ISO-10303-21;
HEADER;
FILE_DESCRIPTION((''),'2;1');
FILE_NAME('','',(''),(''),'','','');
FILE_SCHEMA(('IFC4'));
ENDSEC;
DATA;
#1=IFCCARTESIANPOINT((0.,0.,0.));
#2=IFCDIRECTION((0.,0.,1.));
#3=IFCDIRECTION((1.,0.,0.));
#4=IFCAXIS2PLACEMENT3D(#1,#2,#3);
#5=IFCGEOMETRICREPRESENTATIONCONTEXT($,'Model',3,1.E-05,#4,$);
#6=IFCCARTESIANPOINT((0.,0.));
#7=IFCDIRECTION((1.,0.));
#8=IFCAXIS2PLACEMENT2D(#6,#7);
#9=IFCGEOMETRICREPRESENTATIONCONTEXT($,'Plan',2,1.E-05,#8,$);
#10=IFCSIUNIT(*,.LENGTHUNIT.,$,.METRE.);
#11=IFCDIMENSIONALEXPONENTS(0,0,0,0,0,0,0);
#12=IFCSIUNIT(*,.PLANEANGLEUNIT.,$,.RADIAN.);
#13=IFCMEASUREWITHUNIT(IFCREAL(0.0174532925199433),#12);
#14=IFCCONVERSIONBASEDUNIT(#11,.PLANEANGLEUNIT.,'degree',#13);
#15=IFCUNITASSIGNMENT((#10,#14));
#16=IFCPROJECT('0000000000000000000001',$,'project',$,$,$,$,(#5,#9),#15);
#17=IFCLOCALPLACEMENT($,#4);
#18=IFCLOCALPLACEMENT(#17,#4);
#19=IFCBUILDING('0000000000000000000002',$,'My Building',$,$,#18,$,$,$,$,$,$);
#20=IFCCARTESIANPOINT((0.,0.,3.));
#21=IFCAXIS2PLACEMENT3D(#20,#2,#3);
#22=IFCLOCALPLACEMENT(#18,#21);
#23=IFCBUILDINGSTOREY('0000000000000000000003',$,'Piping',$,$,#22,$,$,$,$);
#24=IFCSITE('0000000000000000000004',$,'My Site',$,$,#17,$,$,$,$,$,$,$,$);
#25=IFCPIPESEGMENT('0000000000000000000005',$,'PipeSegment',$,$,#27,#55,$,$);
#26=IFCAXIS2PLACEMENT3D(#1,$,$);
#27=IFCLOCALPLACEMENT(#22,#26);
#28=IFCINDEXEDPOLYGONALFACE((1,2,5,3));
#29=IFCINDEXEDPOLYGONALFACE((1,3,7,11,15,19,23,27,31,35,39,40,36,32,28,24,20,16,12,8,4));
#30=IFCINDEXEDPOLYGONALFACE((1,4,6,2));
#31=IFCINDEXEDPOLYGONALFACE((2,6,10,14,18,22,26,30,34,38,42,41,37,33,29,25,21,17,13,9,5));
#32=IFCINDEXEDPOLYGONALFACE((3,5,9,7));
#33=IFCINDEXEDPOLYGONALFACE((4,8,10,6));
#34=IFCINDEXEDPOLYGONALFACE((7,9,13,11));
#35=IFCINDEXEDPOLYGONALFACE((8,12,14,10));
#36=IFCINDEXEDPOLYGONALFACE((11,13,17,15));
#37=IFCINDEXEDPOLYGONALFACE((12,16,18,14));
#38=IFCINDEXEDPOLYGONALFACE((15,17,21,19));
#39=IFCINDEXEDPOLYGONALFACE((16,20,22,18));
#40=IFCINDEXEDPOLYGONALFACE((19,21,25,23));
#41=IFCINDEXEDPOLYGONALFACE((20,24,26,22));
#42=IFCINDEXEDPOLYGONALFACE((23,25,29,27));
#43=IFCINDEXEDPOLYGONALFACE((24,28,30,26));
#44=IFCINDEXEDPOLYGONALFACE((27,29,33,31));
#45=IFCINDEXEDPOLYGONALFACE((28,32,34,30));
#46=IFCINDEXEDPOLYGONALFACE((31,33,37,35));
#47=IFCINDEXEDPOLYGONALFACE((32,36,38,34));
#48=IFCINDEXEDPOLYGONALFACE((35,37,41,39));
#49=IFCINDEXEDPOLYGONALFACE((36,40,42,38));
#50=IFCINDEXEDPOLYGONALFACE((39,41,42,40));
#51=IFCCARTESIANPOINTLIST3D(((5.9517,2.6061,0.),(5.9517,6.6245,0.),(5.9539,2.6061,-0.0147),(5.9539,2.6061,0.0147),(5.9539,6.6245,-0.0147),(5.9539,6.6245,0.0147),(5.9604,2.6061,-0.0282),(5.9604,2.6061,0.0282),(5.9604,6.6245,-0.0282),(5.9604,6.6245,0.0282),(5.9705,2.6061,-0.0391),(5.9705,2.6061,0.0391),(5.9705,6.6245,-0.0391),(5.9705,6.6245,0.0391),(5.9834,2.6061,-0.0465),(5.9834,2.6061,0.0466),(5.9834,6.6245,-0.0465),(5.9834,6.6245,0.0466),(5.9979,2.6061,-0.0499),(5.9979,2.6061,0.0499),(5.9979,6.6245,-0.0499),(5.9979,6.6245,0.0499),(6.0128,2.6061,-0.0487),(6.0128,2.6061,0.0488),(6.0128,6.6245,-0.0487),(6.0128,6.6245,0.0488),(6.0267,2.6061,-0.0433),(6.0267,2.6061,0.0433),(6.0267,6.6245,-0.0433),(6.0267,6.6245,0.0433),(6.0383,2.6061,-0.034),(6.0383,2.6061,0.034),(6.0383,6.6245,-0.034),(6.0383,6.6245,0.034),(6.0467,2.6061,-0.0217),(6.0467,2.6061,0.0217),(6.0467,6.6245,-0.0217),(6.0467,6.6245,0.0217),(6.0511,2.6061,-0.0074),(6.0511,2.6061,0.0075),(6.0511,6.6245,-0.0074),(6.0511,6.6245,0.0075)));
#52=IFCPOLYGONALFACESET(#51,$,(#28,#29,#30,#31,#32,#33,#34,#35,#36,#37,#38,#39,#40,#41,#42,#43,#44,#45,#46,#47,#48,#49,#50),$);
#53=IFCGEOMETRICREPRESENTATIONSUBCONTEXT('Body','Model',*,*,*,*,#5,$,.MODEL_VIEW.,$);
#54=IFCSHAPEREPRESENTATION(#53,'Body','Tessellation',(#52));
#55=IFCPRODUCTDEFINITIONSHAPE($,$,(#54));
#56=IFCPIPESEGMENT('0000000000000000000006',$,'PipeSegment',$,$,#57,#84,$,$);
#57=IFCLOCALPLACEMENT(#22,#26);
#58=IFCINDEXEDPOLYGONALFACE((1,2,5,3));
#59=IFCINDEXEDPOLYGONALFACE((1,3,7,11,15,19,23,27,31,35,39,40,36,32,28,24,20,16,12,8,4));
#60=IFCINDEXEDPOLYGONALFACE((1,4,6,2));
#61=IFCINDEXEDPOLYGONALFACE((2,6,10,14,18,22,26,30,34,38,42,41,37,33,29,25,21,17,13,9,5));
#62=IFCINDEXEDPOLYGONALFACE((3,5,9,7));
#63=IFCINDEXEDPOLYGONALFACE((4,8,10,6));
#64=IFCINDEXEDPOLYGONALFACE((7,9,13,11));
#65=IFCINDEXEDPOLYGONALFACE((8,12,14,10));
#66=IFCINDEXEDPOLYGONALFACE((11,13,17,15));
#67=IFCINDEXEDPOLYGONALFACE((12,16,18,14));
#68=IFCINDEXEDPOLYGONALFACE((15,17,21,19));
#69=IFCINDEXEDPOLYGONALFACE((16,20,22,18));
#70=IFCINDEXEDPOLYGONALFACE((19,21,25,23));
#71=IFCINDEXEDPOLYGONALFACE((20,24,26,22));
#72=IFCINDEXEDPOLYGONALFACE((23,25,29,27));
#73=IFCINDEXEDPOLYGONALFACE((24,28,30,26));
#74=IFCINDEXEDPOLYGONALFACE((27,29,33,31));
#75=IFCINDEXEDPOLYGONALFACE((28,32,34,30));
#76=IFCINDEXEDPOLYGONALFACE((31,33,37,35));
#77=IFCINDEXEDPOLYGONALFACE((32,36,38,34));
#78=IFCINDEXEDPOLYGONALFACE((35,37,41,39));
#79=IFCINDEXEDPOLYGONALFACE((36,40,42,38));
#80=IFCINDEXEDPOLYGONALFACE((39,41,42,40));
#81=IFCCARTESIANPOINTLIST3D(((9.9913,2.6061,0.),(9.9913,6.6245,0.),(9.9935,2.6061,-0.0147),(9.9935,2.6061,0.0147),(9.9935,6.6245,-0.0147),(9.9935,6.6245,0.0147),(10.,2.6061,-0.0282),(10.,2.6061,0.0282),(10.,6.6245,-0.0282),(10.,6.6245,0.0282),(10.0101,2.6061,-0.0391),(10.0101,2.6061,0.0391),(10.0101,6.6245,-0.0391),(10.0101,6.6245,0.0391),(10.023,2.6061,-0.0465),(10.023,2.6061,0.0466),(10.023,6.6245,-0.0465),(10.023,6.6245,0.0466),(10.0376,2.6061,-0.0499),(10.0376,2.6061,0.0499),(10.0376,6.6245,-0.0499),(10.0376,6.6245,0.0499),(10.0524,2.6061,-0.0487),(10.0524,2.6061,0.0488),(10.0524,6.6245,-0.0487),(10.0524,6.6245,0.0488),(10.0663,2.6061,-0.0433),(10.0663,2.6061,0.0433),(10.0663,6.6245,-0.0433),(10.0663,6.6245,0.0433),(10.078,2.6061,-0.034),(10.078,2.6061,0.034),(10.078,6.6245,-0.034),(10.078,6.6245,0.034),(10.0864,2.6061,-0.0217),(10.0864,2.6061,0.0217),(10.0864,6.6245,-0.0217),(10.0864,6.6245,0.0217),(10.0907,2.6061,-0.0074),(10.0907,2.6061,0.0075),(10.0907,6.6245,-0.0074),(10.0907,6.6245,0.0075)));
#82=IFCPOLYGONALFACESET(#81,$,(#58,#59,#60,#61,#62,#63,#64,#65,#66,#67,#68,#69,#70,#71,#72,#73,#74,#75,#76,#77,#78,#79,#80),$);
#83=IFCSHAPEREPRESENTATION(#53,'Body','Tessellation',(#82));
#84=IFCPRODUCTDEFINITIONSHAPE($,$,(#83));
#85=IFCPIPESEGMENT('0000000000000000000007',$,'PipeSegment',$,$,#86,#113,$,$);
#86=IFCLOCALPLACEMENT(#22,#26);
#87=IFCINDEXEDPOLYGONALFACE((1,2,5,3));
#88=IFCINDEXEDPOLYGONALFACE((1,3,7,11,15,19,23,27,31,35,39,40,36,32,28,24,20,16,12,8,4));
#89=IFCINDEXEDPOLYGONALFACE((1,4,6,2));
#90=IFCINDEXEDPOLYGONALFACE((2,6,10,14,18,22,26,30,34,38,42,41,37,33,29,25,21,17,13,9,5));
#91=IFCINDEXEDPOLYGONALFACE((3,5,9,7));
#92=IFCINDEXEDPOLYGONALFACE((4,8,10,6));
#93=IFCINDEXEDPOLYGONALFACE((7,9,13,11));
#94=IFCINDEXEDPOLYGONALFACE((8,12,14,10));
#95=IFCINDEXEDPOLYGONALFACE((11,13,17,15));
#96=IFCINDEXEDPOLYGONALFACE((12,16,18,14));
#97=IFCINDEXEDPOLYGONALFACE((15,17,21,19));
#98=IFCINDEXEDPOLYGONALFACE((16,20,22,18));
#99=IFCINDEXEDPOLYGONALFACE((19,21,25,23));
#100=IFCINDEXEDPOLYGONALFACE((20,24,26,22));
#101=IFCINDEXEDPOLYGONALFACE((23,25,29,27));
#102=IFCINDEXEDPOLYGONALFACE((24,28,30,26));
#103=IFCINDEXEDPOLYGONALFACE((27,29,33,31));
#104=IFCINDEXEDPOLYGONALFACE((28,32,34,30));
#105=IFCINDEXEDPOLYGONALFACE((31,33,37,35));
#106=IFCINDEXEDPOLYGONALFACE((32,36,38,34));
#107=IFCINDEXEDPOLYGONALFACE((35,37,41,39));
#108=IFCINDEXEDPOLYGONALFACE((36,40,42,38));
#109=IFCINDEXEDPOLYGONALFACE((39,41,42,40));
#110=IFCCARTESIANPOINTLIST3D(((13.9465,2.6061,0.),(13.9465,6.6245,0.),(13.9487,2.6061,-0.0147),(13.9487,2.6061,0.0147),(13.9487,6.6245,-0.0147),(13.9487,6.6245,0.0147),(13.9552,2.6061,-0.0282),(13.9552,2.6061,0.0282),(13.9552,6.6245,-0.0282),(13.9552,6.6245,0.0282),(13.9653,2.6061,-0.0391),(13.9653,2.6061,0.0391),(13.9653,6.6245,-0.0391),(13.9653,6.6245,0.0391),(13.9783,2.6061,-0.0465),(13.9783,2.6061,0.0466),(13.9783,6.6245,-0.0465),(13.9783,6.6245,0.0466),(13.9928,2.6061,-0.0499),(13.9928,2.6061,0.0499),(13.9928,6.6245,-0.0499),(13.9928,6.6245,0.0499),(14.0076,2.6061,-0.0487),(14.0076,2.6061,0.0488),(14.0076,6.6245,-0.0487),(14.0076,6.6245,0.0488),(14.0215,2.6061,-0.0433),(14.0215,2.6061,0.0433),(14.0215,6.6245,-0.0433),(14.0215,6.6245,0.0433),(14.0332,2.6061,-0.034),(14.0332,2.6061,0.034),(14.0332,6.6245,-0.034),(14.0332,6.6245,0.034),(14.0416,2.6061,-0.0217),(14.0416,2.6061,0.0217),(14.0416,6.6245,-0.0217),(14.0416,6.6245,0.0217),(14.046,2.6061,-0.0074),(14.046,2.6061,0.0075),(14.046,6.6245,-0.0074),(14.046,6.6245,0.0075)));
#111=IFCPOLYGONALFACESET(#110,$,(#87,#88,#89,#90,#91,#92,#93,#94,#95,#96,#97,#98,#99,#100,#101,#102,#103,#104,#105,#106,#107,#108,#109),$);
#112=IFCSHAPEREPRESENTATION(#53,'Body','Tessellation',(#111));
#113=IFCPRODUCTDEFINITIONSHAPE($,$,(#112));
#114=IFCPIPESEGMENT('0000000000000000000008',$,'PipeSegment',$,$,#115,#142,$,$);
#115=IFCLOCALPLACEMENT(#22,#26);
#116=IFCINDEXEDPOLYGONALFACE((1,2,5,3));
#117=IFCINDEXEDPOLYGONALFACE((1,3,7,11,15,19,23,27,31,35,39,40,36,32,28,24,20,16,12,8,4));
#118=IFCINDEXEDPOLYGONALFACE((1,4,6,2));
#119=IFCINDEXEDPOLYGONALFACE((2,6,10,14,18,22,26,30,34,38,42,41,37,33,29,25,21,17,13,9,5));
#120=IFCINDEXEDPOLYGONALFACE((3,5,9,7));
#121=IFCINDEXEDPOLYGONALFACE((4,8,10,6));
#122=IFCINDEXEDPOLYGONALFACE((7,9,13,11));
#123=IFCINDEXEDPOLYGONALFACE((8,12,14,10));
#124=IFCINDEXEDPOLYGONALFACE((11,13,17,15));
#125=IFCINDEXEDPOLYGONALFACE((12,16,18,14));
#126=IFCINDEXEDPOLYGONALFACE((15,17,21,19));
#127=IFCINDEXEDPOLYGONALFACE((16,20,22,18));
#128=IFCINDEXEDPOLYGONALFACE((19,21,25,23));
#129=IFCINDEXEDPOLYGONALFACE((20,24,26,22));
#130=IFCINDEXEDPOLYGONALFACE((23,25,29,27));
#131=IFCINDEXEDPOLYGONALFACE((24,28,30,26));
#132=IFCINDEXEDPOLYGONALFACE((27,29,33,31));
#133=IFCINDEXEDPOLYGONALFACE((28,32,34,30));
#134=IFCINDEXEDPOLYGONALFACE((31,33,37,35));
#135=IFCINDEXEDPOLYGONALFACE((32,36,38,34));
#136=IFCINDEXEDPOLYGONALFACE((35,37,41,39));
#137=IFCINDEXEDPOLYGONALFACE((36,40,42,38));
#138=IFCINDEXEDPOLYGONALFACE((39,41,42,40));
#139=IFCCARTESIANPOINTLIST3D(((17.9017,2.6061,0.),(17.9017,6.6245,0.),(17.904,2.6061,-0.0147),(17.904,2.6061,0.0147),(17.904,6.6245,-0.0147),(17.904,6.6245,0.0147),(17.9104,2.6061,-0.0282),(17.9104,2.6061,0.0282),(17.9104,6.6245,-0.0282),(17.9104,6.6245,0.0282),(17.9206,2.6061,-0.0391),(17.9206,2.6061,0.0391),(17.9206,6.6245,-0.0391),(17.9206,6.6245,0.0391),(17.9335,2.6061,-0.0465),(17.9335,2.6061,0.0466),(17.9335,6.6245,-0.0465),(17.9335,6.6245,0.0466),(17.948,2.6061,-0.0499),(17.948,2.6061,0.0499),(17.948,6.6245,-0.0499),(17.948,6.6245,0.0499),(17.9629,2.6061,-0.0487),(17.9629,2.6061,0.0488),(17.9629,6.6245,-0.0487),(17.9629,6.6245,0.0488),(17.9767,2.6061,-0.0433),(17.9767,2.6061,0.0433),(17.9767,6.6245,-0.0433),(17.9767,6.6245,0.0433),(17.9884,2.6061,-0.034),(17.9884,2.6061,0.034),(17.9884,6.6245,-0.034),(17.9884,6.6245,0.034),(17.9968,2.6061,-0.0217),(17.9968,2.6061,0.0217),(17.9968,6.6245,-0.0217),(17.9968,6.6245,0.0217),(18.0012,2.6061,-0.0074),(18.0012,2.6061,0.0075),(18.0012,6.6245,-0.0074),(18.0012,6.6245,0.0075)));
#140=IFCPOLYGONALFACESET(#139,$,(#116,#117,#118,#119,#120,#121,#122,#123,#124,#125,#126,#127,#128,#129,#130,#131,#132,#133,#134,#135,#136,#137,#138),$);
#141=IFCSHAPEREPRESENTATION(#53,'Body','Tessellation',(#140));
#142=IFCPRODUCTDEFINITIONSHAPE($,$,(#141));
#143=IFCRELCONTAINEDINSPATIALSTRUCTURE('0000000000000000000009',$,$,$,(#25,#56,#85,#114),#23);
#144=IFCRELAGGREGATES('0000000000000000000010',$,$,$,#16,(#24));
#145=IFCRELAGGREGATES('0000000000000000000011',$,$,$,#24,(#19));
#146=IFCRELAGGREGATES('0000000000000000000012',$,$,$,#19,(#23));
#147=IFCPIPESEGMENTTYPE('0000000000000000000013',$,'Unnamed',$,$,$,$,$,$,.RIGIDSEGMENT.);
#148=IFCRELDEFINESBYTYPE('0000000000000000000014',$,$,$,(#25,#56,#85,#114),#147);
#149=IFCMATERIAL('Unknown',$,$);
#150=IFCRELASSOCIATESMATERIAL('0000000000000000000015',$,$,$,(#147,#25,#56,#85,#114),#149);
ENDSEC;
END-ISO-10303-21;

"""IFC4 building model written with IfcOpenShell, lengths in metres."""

from ifc_helpers import new_model, entity, si_unit, converted_unit, frame, origin_with_axes, origin_2d_with_axis, place, context, subcontext, project, spatial, circle, extrude, material, material_profile, profile_set, profile_usage, type_object, element, save


model = new_model("IFC4")

# Units and contexts
model_context = context("Model", 3, precision=1e-05, world=origin_with_axes())
plan_context = context("Plan", 2, precision=1e-05, world=origin_2d_with_axis())
body_context = subcontext(model_context, "Body", "Model", "MODEL_VIEW")
ifc_project = project(units=[si_unit("LENGTHUNIT", "METRE"), converted_unit("PLANEANGLEUNIT", "degree", entity("IfcReal", 0.0174532925199433), si_unit("PLANEANGLEUNIT", "RADIAN"), dimensions=[0, 0, 0, 0, 0, 0, 0])], contexts=[model_context, plan_context])

# Site, building, storey
site_placement = place(None, origin_with_axes())
site = spatial("IfcSite", under=ifc_project, at=site_placement, Name="My Site")
building_placement = place(site_placement, origin_with_axes())
building = spatial("IfcBuilding", under=site, at=building_placement, Name="My Building")
storey_placement = place(building_placement, frame((0.0, 0.0, 3.0), z_axis=(0.0, 0.0, 1.0), x_axis=(1.0, 0.0, 0.0)))
storey = spatial("IfcBuildingStorey", under=building, at=storey_placement, Name="Piping")

# Pipe segments
ifc_material = material(Name="Unknown")
ifc_material_profile = material_profile(ifc_material, circle(Radius=0.05))
ifc_profile_set = profile_set([ifc_material_profile])
pipe_segment_type = type_object("IfcPipeSegmentType", Name="Unnamed", PredefinedType="RIGIDSEGMENT", material=ifc_profile_set)
ifc_profile_usage_1 = profile_usage(ifc_profile_set, cardinal=5)
pipe_segment_1_placement = place(storey_placement, frame((6.0017, 2.6061, 0.0), z_axis=(0.0, 1.0, 0.0), x_axis=(-1.0, 0.0, 0.0)))
element("IfcPipeSegment", 1, at=pipe_segment_1_placement, inside=storey, type_object=pipe_segment_type, material=ifc_profile_usage_1, Name="PipeSegment", context=body_context, shape_type="SweptSolid", body=[
    extrude(circle(Radius=0.05), origin_with_axes(), (0.0, 0.0, 1.0), 4.0184),
])
ifc_profile_usage_2 = profile_usage(ifc_profile_set, cardinal=5)
pipe_segment_2_placement = place(storey_placement, frame((10.0413, 2.6061, 0.0), z_axis=(0.0, 1.0, 0.0), x_axis=(-1.0, 0.0, 0.0)))
element("IfcPipeSegment", 2, at=pipe_segment_2_placement, inside=storey, type_object=pipe_segment_type, material=ifc_profile_usage_2, Name="PipeSegment", context=body_context, shape_type="SweptSolid", body=[
    extrude(circle(Radius=0.05), origin_with_axes(), (0.0, 0.0, 1.0), 4.0184),
])
ifc_profile_usage_3 = profile_usage(ifc_profile_set, cardinal=5)
pipe_segment_3_placement = place(storey_placement, frame((13.9965, 2.6061, 0.0), z_axis=(0.0, 1.0, 0.0), x_axis=(-1.0, 0.0, 0.0)))
element("IfcPipeSegment", 3, at=pipe_segment_3_placement, inside=storey, type_object=pipe_segment_type, material=ifc_profile_usage_3, Name="PipeSegment", context=body_context, shape_type="SweptSolid", body=[
    extrude(circle(Radius=0.05), origin_with_axes(), (0.0, 0.0, 1.0), 4.0184),
])
ifc_profile_usage_4 = profile_usage(ifc_profile_set, cardinal=5)
pipe_segment_4_placement = place(storey_placement, frame((17.9517, 2.6061, 0.0), z_axis=(0.0, 1.0, 0.0), x_axis=(-1.0, 0.0, 0.0)))
element("IfcPipeSegment", 4, at=pipe_segment_4_placement, inside=storey, type_object=pipe_segment_type, material=ifc_profile_usage_4, Name="PipeSegment", context=body_context, shape_type="SweptSolid", body=[
    extrude(circle(Radius=0.05), origin_with_axes(), (0.0, 0.0, 1.0), 4.0184),
])

save(model, "model.ifc")
